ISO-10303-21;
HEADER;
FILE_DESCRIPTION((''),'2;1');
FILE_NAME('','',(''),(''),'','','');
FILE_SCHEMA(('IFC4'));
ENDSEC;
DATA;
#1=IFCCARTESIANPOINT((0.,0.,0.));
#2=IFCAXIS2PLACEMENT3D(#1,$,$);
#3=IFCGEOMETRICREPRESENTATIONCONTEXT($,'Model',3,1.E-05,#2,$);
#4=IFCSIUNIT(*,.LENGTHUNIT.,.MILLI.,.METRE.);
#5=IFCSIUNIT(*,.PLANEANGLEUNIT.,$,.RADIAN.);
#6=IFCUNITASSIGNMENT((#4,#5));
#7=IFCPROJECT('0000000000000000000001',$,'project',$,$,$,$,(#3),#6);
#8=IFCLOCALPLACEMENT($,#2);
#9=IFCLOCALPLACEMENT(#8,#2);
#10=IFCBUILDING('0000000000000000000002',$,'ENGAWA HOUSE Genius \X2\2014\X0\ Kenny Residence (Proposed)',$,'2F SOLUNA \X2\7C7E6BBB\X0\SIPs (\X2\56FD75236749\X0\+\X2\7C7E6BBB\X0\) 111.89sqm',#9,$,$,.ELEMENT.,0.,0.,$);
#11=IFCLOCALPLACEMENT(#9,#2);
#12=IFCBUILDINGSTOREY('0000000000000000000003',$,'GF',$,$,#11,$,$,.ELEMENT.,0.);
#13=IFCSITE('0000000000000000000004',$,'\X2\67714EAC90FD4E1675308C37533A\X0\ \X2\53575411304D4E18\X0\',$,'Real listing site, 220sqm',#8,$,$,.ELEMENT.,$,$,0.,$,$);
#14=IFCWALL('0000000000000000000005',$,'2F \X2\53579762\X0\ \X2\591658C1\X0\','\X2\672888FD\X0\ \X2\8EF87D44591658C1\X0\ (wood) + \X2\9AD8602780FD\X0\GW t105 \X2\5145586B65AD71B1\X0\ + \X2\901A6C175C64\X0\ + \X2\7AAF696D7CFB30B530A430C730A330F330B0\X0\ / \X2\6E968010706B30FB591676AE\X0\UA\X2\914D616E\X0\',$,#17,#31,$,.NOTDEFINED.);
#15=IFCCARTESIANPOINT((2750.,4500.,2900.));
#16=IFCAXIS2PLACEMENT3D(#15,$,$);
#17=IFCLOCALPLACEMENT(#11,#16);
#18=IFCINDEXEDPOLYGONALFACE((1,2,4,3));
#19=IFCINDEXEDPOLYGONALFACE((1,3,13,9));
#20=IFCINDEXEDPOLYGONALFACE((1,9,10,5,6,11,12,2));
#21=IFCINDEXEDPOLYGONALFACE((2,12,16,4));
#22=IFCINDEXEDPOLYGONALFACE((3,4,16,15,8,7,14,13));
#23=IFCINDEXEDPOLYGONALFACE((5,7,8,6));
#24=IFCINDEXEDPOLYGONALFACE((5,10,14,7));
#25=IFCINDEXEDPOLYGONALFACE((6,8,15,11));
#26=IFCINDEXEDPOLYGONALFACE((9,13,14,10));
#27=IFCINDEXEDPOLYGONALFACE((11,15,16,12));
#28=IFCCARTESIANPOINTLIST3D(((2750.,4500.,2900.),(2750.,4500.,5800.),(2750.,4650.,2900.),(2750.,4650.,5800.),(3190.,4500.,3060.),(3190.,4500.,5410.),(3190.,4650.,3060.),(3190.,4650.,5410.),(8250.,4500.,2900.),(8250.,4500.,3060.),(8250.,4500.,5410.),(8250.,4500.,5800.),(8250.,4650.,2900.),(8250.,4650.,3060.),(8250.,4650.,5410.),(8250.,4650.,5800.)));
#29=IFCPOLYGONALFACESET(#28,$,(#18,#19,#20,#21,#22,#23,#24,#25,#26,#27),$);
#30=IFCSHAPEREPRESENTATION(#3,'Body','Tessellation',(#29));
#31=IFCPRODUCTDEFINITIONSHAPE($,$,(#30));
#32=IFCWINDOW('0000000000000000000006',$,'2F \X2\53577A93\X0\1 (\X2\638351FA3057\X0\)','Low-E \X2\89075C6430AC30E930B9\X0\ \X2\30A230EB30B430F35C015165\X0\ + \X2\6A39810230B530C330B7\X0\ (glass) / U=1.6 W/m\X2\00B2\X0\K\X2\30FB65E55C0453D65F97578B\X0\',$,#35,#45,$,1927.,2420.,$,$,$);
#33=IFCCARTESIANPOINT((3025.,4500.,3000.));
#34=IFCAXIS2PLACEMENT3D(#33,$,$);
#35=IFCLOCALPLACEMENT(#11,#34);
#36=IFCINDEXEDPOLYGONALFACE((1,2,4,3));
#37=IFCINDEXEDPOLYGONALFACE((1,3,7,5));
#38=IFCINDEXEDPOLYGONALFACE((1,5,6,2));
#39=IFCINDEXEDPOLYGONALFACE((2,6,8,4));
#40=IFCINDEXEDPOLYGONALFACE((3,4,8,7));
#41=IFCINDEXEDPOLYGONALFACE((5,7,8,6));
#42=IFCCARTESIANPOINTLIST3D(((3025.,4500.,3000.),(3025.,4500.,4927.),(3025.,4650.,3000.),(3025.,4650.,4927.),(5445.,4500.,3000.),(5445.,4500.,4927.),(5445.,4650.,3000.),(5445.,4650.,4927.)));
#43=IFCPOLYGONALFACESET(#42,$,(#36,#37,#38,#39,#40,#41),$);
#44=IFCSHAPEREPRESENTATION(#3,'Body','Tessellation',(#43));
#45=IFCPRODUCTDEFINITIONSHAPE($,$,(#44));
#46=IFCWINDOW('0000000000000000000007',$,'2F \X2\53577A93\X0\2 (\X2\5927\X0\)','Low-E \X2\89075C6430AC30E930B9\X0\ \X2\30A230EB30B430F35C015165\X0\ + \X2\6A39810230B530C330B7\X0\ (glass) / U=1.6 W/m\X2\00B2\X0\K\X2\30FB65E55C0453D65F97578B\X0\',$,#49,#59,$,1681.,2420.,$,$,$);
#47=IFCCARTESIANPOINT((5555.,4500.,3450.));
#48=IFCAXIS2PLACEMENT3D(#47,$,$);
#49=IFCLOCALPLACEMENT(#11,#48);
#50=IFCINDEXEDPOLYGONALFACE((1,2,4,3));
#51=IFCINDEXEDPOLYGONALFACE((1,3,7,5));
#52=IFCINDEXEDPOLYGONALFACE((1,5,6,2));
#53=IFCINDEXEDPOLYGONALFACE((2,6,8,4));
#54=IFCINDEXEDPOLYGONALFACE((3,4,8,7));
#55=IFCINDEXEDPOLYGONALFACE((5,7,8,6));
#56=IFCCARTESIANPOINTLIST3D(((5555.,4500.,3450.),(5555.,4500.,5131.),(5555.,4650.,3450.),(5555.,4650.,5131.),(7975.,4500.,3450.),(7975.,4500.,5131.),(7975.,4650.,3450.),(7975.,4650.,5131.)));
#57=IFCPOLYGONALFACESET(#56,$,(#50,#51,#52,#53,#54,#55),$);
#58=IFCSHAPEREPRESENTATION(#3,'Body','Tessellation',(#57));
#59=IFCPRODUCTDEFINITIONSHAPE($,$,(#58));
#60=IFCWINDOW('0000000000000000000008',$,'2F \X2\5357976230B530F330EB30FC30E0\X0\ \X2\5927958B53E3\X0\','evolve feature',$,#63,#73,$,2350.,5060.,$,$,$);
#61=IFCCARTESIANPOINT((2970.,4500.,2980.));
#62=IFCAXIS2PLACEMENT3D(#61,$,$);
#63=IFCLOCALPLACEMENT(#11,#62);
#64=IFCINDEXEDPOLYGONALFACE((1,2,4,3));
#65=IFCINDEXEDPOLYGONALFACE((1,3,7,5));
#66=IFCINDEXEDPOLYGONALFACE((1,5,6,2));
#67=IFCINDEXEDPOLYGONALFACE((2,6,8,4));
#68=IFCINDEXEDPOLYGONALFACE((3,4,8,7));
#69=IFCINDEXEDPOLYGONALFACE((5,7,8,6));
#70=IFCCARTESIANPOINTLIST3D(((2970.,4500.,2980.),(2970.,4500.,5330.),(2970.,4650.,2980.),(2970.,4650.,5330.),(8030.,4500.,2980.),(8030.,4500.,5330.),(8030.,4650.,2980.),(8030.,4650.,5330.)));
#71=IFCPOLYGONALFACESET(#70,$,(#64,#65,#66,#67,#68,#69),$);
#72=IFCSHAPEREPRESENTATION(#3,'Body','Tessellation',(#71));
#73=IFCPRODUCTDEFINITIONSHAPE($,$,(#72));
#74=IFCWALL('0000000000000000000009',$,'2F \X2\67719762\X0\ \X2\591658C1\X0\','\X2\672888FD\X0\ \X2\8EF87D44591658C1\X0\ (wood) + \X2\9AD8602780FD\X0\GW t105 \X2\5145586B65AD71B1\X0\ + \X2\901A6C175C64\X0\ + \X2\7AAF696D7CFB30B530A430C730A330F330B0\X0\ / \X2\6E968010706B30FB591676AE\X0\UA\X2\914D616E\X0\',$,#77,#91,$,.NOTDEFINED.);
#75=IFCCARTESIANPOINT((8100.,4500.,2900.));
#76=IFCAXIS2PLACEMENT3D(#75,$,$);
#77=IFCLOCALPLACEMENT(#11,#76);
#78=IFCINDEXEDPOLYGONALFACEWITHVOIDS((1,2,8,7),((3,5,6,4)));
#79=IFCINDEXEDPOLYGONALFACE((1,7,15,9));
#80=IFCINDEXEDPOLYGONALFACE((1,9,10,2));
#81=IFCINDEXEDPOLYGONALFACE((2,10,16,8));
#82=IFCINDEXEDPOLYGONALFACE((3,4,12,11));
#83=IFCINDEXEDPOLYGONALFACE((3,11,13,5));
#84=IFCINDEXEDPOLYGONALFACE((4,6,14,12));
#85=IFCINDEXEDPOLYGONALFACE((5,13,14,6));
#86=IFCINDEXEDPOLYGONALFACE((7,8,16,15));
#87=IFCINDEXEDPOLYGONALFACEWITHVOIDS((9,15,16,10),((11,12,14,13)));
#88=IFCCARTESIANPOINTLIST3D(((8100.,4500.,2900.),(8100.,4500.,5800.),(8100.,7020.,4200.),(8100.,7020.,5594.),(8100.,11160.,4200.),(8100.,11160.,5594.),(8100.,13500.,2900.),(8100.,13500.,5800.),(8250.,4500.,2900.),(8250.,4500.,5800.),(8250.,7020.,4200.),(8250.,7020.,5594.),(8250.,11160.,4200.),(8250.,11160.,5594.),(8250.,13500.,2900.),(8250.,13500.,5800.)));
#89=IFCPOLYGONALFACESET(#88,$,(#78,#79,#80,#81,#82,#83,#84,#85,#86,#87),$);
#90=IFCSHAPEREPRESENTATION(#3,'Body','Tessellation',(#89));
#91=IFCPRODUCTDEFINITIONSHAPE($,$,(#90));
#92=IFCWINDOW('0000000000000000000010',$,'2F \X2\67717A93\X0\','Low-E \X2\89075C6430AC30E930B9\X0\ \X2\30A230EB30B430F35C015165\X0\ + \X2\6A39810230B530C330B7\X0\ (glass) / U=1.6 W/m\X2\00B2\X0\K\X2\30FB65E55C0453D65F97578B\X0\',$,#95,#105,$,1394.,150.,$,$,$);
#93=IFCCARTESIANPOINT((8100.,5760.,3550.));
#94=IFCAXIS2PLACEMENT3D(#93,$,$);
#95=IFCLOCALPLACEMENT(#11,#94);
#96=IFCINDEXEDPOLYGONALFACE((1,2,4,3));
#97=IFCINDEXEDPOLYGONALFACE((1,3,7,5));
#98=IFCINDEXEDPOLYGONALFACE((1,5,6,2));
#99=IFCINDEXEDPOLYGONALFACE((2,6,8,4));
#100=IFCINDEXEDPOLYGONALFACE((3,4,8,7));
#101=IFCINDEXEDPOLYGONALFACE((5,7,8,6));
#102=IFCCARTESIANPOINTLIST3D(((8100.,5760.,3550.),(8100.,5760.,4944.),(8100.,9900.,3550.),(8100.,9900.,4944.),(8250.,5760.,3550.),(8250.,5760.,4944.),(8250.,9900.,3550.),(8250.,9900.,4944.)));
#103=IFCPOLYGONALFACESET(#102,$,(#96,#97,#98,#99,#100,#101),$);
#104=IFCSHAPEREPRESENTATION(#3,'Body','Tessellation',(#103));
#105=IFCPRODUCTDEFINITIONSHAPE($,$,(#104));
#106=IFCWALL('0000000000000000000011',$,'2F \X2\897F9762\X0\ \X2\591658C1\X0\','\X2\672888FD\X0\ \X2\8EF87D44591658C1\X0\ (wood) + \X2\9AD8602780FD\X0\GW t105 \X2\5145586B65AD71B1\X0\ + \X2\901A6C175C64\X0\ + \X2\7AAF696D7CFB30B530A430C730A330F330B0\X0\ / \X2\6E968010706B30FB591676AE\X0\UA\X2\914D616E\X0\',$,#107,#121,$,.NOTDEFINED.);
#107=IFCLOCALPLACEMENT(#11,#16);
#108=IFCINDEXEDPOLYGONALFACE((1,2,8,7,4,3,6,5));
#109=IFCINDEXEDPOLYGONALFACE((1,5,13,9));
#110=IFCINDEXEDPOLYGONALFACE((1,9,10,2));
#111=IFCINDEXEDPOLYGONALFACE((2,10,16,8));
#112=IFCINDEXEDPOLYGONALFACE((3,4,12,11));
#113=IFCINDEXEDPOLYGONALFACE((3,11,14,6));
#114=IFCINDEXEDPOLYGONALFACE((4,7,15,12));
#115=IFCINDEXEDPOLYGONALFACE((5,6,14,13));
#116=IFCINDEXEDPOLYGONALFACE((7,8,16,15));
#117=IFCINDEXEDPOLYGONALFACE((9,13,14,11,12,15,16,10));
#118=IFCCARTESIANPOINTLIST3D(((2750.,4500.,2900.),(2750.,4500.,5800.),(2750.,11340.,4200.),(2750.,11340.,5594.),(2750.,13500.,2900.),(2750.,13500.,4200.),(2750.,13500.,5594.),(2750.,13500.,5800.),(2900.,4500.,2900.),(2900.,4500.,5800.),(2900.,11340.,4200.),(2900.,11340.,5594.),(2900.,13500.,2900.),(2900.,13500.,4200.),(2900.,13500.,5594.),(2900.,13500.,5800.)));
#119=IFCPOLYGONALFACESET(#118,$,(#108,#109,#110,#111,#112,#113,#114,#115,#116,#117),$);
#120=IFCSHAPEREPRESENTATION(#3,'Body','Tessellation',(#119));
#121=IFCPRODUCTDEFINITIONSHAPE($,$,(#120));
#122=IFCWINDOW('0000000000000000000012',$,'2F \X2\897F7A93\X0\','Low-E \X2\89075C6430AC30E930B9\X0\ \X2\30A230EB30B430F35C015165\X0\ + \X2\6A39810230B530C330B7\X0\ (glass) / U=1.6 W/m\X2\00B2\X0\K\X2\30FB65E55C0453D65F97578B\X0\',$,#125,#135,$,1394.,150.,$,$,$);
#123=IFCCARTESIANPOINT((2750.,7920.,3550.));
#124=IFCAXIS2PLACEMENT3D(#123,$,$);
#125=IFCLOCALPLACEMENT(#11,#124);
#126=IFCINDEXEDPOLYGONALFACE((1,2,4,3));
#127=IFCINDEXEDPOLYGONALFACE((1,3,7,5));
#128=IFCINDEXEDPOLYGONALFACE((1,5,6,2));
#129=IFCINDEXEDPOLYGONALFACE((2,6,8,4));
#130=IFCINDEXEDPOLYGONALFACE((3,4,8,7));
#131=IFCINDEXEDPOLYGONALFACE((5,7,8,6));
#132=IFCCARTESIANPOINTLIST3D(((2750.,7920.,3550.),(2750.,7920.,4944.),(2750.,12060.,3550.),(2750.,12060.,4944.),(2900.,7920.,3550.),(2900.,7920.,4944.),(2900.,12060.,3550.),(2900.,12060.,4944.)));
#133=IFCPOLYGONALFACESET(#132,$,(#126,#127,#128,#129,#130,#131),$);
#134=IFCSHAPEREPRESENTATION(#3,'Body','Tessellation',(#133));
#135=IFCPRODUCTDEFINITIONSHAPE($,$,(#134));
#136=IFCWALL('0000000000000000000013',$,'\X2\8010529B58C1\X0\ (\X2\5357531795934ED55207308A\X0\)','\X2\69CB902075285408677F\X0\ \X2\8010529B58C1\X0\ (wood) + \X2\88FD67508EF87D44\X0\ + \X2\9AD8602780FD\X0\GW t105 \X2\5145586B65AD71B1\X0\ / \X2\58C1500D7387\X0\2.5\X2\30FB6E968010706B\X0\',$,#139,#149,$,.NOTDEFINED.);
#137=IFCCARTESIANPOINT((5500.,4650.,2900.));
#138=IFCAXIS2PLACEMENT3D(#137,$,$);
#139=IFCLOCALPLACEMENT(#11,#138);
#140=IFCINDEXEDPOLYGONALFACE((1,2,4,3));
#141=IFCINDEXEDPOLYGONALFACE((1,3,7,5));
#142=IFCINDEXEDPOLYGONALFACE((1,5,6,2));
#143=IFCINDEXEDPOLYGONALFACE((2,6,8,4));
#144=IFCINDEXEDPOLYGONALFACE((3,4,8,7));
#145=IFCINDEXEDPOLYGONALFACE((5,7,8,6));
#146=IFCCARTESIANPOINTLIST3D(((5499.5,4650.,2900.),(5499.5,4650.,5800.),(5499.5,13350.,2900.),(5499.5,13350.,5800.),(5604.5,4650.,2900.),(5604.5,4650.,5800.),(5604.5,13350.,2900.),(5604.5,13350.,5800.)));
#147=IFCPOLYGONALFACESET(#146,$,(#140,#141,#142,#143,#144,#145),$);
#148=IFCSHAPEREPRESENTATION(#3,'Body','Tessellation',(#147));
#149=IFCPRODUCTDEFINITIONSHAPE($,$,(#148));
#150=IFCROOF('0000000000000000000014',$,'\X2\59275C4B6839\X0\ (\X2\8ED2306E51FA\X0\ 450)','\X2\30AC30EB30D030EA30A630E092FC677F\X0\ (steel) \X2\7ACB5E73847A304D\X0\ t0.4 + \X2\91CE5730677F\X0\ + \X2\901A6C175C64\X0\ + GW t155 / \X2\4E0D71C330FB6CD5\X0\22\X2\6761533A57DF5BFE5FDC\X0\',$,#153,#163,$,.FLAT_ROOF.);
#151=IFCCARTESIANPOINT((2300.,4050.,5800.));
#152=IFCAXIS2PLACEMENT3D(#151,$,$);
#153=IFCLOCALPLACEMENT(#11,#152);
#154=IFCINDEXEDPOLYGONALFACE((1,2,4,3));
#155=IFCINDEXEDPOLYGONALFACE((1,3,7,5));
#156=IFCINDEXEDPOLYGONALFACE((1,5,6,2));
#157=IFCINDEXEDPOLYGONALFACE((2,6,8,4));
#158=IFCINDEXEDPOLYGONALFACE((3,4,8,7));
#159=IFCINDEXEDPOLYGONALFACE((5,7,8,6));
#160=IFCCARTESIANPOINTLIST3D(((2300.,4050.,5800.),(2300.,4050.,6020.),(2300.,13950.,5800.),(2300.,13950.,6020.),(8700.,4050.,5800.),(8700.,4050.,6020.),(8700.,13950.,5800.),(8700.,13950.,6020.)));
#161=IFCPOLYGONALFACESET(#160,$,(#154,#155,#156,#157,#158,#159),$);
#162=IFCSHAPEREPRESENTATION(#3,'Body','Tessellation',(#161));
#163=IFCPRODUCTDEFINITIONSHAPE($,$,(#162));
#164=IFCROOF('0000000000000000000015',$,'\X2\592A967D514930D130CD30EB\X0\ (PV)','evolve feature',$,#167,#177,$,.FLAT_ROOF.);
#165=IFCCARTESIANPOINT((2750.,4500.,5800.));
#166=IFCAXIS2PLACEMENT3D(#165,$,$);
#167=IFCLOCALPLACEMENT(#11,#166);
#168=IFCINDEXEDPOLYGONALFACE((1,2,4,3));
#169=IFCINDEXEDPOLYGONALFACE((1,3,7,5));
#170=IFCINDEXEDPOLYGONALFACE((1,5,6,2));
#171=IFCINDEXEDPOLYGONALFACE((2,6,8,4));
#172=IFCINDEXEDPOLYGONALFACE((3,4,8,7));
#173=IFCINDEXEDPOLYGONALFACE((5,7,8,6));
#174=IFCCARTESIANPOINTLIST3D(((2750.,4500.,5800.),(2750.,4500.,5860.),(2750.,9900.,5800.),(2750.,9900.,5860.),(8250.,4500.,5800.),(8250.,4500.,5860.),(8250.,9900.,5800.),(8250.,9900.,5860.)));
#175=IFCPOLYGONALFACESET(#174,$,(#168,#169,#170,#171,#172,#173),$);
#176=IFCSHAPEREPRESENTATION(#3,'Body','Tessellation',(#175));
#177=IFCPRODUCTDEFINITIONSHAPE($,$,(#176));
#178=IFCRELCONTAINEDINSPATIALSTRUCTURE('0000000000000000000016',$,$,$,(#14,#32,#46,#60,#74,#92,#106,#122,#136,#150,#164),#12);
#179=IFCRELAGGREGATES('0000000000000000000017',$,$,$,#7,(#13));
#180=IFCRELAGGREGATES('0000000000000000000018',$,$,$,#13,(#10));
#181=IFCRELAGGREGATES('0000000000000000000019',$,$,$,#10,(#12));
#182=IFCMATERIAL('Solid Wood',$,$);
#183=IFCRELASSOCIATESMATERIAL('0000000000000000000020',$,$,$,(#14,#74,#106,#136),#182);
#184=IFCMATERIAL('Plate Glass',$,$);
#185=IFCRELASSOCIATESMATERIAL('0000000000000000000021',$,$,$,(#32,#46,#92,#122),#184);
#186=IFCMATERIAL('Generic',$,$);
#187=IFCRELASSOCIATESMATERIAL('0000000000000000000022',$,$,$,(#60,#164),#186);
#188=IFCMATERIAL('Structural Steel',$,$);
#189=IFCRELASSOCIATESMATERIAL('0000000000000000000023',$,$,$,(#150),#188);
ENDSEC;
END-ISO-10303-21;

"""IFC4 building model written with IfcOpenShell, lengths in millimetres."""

from ifc_helpers import new_model, si_unit, frame, frame_2d, origin, place, context, project, spatial, rectangle, extrude, material, element, fill, save


model = new_model("IFC4")

# Units and contexts
model_context = context("Model", 3, precision=1e-05, world=origin())
ifc_project = project(units=[si_unit("LENGTHUNIT", "METRE", prefix="MILLI"), si_unit("PLANEANGLEUNIT", "RADIAN")], contexts=[model_context])

# Site, building, storey
site_placement = place(None, origin())
site = spatial("IfcSite", under=ifc_project, at=site_placement, Name="東京都世田谷区 南向き丘", ObjectType="Real listing site, 220sqm", CompositionType="ELEMENT", RefElevation=0.0)
building_placement = place(site_placement, origin())
building = spatial("IfcBuilding", under=site, at=building_placement, Name="ENGAWA HOUSE Genius — Kenny Residence (Proposed)", ObjectType="2F SOLUNA 籾殻SIPs (国産杉+籾殻) 111.89sqm", CompositionType="ELEMENT", ElevationOfRefHeight=0.0, ElevationOfTerrain=0.0)
storey_placement = place(building_placement, origin())
storey = spatial("IfcBuildingStorey", under=building, at=storey_placement, Name="GF", CompositionType="ELEMENT", Elevation=0.0)

# Shared definitions
ifc_material_1 = material(Name="Solid Wood")

# Wall, openings, windows
wall_1_placement = place(storey_placement, frame((2750.0, 4500.0, 2900.0)))
wall_1 = element("IfcWall", 1, at=wall_1_placement, inside=storey, material=ifc_material_1, Name="2F 南面 外壁", Description="木製 軸組外壁 (wood) + 高性能GW t105 充填断熱 + 通気層 + 窯業系サイディング / 準耐火・外皮UA配慮", PredefinedType="NOTDEFINED", context=model_context, shape_type="SweptSolid", body=[
    extrude(rectangle(XDim=5500.0, YDim=150.0, at=frame_2d((2750.0, 75.0))), frame((2750.0, 4500.0, 2900.0)), (0.0, 0.0, 1.0), 2900.0),
])
opening_1_placement = place(storey_placement, frame((3025.0, 4500.0, 3000.0)))
opening_1 = element("IfcOpeningElement", 2, at=opening_1_placement, cuts=wall_1, PredefinedType="NOTDEFINED", context=model_context, shape_type="SweptSolid", body=[
    extrude(rectangle(XDim=2420.0, YDim=150.0, at=frame_2d((1210.0, 75.0))), frame((3025.0, 4500.0, 3000.0)), (0.0, 0.0, 1.0), 1927.0),
])
opening_2_placement = place(storey_placement, frame((5555.0, 4500.0, 3450.0)))
opening_2 = element("IfcOpeningElement", 3, at=opening_2_placement, cuts=wall_1, PredefinedType="NOTDEFINED", context=model_context, shape_type="SweptSolid", body=[
    extrude(rectangle(XDim=2420.0, YDim=150.0, at=frame_2d((1210.0, 75.0))), frame((5555.0, 4500.0, 3450.0)), (0.0, 0.0, 1.0), 1681.0),
])
opening_3_placement = place(storey_placement, frame((2970.0, 4500.0, 2980.0)))
opening_3 = element("IfcOpeningElement", 4, at=opening_3_placement, cuts=wall_1, PredefinedType="NOTDEFINED", context=model_context, shape_type="SweptSolid", body=[
    extrude(rectangle(XDim=5060.0, YDim=150.0, at=frame_2d((2530.0, 75.0))), frame((2970.0, 4500.0, 2980.0)), (0.0, 0.0, 1.0), 2350.0),
])
ifc_material_2 = material(Name="Plate Glass")
window_1_placement = place(storey_placement, frame((3025.0, 4500.0, 3000.0)))
window_1 = element("IfcWindow", 5, at=window_1_placement, inside=storey, material=ifc_material_2, Name="2F 南窓1 (掃出し)", Description="Low-E 複層ガラス アルゴン封入 + 樹脂サッシ (glass) / U=1.6 W/m²K・日射取得型", OverallHeight=1927.0, OverallWidth=2420.0, context=model_context, shape_type="SweptSolid", body=[
    extrude(rectangle(XDim=2420.0, YDim=150.0, at=frame_2d((1210.0, 75.0))), frame((3025.0, 4500.0, 3000.0)), (0.0, 0.0, 1.0), 1927.0),
])
fill(opening_1, window_1)
window_2_placement = place(storey_placement, frame((5555.0, 4500.0, 3450.0)))
window_2 = element("IfcWindow", 6, at=window_2_placement, inside=storey, material=ifc_material_2, Name="2F 南窓2 (大)", Description="Low-E 複層ガラス アルゴン封入 + 樹脂サッシ (glass) / U=1.6 W/m²K・日射取得型", OverallHeight=1681.0, OverallWidth=2420.0, context=model_context, shape_type="SweptSolid", body=[
    extrude(rectangle(XDim=2420.0, YDim=150.0, at=frame_2d((1210.0, 75.0))), frame((5555.0, 4500.0, 3450.0)), (0.0, 0.0, 1.0), 1681.0),
])
fill(opening_2, window_2)
ifc_material_3 = material(Name="Generic")
window_3_placement = place(storey_placement, frame((2970.0, 4500.0, 2980.0)))
window_3 = element("IfcWindow", 7, at=window_3_placement, inside=storey, material=ifc_material_3, Name="2F 南面サンルーム 大開口", Description="evolve feature", OverallHeight=2350.0, OverallWidth=5060.0, context=model_context, shape_type="SweptSolid", body=[
    extrude(rectangle(XDim=5060.0, YDim=150.0, at=frame_2d((2530.0, 75.0))), frame((2970.0, 4500.0, 2980.0)), (0.0, 0.0, 1.0), 2350.0),
])
fill(opening_3, window_3)

# Walls, openings, windows
wall_2_placement = place(storey_placement, frame((8100.0, 4500.0, 2900.0)))
wall_2 = element("IfcWall", 8, at=wall_2_placement, inside=storey, material=ifc_material_1, Name="2F 東面 外壁", Description="木製 軸組外壁 (wood) + 高性能GW t105 充填断熱 + 通気層 + 窯業系サイディング / 準耐火・外皮UA配慮", PredefinedType="NOTDEFINED", context=model_context, shape_type="SweptSolid", body=[
    extrude(rectangle(XDim=150.0, YDim=9000.0, at=frame_2d((75.0, 4500.0))), frame((8100.0, 4500.0, 2900.0)), (0.0, 0.0, 1.0), 2900.0),
])
opening_4_placement = place(storey_placement, frame((8100.0, 5760.0, 3550.0)))
opening_4 = element("IfcOpeningElement", 9, at=opening_4_placement, cuts=wall_2, PredefinedType="NOTDEFINED", context=model_context, shape_type="SweptSolid", body=[
    extrude(rectangle(XDim=150.0, YDim=4140.0, at=frame_2d((75.0, 2070.0))), frame((8100.0, 5760.0, 3550.0)), (0.0, 0.0, 1.0), 1394.0),
])
window_4_placement = place(storey_placement, frame((8100.0, 5760.0, 3550.0)))
window_4 = element("IfcWindow", 10, at=window_4_placement, inside=storey, material=ifc_material_2, Name="2F 東窓", Description="Low-E 複層ガラス アルゴン封入 + 樹脂サッシ (glass) / U=1.6 W/m²K・日射取得型", OverallHeight=1394.0, OverallWidth=150.0, context=model_context, shape_type="SweptSolid", body=[
    extrude(rectangle(XDim=150.0, YDim=4140.0, at=frame_2d((75.0, 2070.0))), frame((8100.0, 5760.0, 3550.0)), (0.0, 0.0, 1.0), 1394.0),
])
fill(opening_4, window_4)
wall_3_placement = place(storey_placement, frame((2750.0, 4500.0, 2900.0)))
wall_3 = element("IfcWall", 11, at=wall_3_placement, inside=storey, material=ifc_material_1, Name="2F 西面 外壁", Description="木製 軸組外壁 (wood) + 高性能GW t105 充填断熱 + 通気層 + 窯業系サイディング / 準耐火・外皮UA配慮", PredefinedType="NOTDEFINED", context=model_context, shape_type="SweptSolid", body=[
    extrude(rectangle(XDim=150.0, YDim=9000.0, at=frame_2d((75.0, 4500.0))), frame((2750.0, 4500.0, 2900.0)), (0.0, 0.0, 1.0), 2900.0),
])
opening_5_placement = place(storey_placement, frame((2750.0, 7920.0, 3550.0)))
opening_5 = element("IfcOpeningElement", 12, at=opening_5_placement, cuts=wall_3, PredefinedType="NOTDEFINED", context=model_context, shape_type="SweptSolid", body=[
    extrude(rectangle(XDim=150.0, YDim=4140.0, at=frame_2d((75.0, 2070.0))), frame((2750.0, 7920.0, 3550.0)), (0.0, 0.0, 1.0), 1394.0),
])
window_5_placement = place(storey_placement, frame((2750.0, 7920.0, 3550.0)))
window_5 = element("IfcWindow", 13, at=window_5_placement, inside=storey, material=ifc_material_2, Name="2F 西窓", Description="Low-E 複層ガラス アルゴン封入 + 樹脂サッシ (glass) / U=1.6 W/m²K・日射取得型", OverallHeight=1394.0, OverallWidth=150.0, context=model_context, shape_type="SweptSolid", body=[
    extrude(rectangle(XDim=150.0, YDim=4140.0, at=frame_2d((75.0, 2070.0))), frame((2750.0, 7920.0, 3550.0)), (0.0, 0.0, 1.0), 1394.0),
])
fill(opening_5, window_5)

# Wall
wall_4_placement = place(storey_placement, frame((5500.0, 4650.0, 2900.0)))
element("IfcWall", 14, at=wall_4_placement, inside=storey, material=ifc_material_1, Name="耐力壁 (南北間仕切り)", Description="構造用合板 耐力壁 (wood) + 製材軸組 + 高性能GW t105 充填断熱 / 壁倍率2.5・準耐火", PredefinedType="NOTDEFINED", context=model_context, shape_type="SweptSolid", body=[
    extrude(rectangle(XDim=105.0, YDim=8700.0, at=frame_2d((52.0, 4350.0))), frame((5500.0, 4650.0, 2900.0)), (0.0, 0.0, 1.0), 2900.0),
])

# Roofs
ifc_material_4 = material(Name="Structural Steel")
roof_1_placement = place(storey_placement, frame((2300.0, 4050.0, 5800.0)))
element("IfcRoof", 15, at=roof_1_placement, inside=storey, material=ifc_material_4, Name="大屋根 (軒の出 450)", Description="ガルバリウム鋼板 (steel) 立平葺き t0.4 + 野地板 + 通気層 + GW t155 / 不燃・法22条区域対応", PredefinedType="FLAT_ROOF", context=model_context, shape_type="SweptSolid", body=[
    extrude(rectangle(XDim=6400.0, YDim=9900.0, at=frame_2d((3200.0, 4950.0))), frame((2300.0, 4050.0, 5800.0)), (0.0, 0.0, 1.0), 220.0),
])
roof_2_placement = place(storey_placement, frame((2750.0, 4500.0, 5800.0)))
element("IfcRoof", 16, at=roof_2_placement, inside=storey, material=ifc_material_3, Name="太陽光パネル (PV)", Description="evolve feature", PredefinedType="FLAT_ROOF", context=model_context, shape_type="SweptSolid", body=[
    extrude(rectangle(XDim=5500.0, YDim=5400.0, at=frame_2d((2750.0, 2700.0))), frame((2750.0, 4500.0, 5800.0)), (0.0, 0.0, 1.0), 60.0),
])

save(model, "model.ifc")
